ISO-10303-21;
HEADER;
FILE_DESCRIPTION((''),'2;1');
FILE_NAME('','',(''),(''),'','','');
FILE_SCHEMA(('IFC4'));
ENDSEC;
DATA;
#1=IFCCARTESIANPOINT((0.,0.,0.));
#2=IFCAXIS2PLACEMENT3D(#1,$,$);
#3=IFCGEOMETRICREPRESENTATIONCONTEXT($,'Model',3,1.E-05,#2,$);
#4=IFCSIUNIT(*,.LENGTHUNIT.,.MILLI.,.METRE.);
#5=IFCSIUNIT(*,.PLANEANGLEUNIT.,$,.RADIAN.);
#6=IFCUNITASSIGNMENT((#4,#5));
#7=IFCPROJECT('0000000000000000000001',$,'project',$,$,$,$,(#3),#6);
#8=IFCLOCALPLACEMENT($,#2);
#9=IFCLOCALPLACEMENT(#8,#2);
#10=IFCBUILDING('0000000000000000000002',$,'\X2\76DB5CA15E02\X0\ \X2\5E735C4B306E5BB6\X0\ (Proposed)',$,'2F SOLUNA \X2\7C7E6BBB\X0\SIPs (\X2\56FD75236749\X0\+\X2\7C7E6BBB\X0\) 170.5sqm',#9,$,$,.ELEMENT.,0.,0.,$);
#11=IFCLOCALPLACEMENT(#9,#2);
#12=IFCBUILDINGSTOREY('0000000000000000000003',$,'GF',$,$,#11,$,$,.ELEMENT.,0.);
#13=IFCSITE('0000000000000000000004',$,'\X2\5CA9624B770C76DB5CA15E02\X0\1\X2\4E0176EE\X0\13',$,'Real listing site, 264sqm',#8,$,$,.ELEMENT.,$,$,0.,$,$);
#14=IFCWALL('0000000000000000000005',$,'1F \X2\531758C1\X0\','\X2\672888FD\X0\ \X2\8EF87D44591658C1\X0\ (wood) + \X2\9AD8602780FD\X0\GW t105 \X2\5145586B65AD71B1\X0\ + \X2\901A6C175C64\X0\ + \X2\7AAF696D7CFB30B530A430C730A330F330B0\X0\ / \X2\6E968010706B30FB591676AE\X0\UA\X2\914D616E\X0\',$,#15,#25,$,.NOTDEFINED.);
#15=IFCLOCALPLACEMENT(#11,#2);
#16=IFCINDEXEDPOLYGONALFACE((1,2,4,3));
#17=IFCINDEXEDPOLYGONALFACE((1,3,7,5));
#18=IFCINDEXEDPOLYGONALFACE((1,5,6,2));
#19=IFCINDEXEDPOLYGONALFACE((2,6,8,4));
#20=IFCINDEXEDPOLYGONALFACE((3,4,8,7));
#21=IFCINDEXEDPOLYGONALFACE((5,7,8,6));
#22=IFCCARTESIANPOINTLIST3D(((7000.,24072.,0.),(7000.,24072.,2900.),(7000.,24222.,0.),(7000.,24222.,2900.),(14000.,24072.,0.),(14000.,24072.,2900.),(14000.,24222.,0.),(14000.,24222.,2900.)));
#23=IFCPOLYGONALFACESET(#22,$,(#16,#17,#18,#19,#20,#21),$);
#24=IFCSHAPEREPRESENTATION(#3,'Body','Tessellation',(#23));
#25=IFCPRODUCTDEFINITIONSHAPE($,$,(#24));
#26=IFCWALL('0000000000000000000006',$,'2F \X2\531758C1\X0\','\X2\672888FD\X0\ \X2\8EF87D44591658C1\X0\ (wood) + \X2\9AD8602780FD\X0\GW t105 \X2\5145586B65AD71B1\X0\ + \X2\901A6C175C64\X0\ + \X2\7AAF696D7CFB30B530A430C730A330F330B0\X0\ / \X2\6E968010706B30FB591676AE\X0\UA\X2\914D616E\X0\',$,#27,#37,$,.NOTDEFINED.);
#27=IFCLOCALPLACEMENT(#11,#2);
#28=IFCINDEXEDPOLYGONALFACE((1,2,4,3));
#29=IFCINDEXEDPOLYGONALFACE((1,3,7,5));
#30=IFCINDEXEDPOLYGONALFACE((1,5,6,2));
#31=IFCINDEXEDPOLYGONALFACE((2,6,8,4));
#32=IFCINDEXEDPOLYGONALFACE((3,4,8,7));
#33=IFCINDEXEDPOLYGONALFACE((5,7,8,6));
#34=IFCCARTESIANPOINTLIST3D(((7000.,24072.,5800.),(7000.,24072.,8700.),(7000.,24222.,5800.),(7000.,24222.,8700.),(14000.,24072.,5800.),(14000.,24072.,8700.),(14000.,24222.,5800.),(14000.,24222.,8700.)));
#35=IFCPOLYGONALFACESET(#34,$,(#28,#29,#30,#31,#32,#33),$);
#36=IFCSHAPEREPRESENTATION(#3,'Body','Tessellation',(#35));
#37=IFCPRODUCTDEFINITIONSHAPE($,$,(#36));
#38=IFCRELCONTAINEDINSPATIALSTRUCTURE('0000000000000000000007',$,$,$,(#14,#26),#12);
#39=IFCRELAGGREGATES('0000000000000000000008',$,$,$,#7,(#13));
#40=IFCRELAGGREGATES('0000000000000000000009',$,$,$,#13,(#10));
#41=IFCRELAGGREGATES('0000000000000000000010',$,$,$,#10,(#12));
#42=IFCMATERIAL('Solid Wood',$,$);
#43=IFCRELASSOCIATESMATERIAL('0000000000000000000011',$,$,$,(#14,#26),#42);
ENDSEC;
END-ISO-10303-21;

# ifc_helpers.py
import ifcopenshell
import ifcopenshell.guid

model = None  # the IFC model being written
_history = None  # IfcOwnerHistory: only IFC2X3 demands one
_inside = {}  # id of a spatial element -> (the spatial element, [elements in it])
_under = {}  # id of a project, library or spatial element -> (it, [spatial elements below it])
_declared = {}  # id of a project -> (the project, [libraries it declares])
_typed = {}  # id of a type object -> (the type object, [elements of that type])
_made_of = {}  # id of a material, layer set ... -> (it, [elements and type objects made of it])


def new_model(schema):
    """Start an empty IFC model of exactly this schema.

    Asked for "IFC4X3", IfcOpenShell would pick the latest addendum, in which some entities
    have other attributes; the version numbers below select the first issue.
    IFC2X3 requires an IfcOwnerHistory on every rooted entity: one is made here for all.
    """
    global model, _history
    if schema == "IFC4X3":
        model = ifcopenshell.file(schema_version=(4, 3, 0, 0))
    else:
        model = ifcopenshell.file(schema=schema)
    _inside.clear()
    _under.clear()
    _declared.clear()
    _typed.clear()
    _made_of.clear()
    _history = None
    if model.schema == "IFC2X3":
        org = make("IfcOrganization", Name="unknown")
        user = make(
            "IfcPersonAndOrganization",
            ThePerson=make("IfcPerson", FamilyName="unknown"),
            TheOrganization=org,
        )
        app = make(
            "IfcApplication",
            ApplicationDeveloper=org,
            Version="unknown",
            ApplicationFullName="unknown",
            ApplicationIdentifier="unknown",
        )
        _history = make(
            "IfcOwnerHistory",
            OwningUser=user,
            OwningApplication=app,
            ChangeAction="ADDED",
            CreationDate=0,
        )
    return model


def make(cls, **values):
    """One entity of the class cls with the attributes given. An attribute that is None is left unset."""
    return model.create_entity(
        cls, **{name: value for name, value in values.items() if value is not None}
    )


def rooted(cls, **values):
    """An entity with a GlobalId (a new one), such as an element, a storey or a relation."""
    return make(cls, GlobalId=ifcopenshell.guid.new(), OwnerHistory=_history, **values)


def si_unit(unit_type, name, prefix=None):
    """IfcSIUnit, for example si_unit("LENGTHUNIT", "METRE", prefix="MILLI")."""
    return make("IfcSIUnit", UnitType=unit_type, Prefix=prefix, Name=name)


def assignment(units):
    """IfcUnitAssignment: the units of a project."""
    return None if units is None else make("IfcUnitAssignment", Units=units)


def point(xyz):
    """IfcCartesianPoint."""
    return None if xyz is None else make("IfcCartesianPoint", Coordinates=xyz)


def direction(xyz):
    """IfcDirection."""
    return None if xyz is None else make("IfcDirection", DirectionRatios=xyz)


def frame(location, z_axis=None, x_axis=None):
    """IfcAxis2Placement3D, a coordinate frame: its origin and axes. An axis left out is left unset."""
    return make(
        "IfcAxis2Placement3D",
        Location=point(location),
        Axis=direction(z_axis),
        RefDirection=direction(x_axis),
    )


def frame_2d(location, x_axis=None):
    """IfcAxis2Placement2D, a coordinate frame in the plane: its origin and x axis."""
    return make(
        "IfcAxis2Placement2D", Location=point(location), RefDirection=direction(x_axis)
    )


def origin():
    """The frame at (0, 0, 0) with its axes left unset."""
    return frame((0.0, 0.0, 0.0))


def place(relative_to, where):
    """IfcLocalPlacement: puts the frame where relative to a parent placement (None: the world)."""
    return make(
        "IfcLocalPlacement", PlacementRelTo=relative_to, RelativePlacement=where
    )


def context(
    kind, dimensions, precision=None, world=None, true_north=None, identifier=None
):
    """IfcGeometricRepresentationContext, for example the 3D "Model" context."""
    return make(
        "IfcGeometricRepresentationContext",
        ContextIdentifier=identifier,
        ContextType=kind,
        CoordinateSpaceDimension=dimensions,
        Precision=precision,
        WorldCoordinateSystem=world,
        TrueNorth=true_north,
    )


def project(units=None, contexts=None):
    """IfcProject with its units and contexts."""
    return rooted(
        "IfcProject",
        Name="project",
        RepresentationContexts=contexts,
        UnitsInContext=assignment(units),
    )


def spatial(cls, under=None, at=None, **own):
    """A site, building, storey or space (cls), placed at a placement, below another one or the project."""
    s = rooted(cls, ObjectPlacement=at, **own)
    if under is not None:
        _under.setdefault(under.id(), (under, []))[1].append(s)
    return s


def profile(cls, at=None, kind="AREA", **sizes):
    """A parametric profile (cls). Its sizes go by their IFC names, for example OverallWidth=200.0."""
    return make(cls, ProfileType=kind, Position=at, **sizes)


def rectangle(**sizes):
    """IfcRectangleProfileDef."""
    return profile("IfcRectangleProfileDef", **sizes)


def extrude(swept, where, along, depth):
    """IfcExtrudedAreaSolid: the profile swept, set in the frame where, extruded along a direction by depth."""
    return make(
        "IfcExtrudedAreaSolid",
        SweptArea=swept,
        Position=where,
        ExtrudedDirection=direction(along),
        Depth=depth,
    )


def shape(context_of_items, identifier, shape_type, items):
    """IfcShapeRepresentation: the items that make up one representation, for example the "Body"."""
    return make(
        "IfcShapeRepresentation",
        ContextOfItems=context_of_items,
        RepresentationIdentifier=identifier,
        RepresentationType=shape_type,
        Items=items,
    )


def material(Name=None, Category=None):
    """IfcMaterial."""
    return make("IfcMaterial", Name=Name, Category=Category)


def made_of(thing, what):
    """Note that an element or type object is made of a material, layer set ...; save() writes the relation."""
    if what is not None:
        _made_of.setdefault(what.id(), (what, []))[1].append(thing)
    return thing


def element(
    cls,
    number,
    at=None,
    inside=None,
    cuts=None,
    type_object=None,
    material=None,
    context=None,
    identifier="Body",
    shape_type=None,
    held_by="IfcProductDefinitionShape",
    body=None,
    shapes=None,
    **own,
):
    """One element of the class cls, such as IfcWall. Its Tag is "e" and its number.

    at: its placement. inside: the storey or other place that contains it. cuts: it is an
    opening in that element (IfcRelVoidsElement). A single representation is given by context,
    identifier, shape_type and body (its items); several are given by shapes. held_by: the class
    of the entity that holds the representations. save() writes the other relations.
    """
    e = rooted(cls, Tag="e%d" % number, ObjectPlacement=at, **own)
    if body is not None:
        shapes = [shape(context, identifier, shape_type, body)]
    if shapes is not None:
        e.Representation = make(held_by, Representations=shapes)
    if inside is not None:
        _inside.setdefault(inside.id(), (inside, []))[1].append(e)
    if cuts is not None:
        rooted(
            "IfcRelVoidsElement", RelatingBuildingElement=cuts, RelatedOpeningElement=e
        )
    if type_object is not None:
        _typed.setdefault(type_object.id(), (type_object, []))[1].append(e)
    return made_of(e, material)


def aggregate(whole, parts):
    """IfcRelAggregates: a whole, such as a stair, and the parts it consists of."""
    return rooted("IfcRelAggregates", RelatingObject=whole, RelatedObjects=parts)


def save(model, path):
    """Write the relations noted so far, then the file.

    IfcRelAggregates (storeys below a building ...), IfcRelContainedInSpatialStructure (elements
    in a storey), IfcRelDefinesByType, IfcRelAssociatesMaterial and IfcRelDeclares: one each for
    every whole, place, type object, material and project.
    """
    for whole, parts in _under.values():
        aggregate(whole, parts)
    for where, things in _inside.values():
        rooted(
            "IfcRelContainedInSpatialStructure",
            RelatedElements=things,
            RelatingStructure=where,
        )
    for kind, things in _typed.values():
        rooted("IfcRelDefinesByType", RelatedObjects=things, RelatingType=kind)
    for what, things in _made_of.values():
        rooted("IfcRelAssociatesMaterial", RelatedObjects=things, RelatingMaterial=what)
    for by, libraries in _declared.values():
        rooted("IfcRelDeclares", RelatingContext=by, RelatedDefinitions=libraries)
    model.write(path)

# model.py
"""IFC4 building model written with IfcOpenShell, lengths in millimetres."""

from ifc_helpers import new_model, si_unit, frame, frame_2d, origin, place, context, project, spatial, rectangle, extrude, material, element, save


model = new_model("IFC4")

# Units and contexts
model_context = context("Model", 3, precision=1e-05, world=origin())
ifc_project = project(units=[si_unit("LENGTHUNIT", "METRE", prefix="MILLI"), si_unit("PLANEANGLEUNIT", "RADIAN")], contexts=[model_context])

# Site, building, storey
site_placement = place(None, origin())
site = spatial("IfcSite", under=ifc_project, at=site_placement, Name="岩手県盛岡市1丁目13", ObjectType="Real listing site, 264sqm", CompositionType="ELEMENT", RefElevation=0.0)
building_placement = place(site_placement, origin())
building = spatial("IfcBuilding", under=site, at=building_placement, Name="盛岡市 平屋の家 (Proposed)", ObjectType="2F SOLUNA 籾殻SIPs (国産杉+籾殻) 170.5sqm", CompositionType="ELEMENT", ElevationOfRefHeight=0.0, ElevationOfTerrain=0.0)
storey_placement = place(building_placement, origin())
storey = spatial("IfcBuildingStorey", under=building, at=storey_placement, Name="GF", CompositionType="ELEMENT", Elevation=0.0)

# Shared definitions
ifc_material_1 = material(Name="Solid Wood")

# Wall
wall_1_placement = place(storey_placement, frame((3500.0, 12036.0, 0.0)))
element("IfcWall", 1, at=wall_1_placement, inside=storey, material=ifc_material_1, Name="1F 北壁", Description="木製 軸組外壁 (wood) + 高性能GW t105 充填断熱 + 通気層 + 窯業系サイディング / 準耐火・外皮UA配慮", PredefinedType="NOTDEFINED", context=model_context, shape_type="SweptSolid", body=[
    extrude(rectangle(XDim=7000.0, YDim=150.0, at=frame_2d((3500.0, 75.0))), frame((3500.0, 12036.0, 0.0)), (0.0, 0.0, 1.0), 2900.0),
])

# Wall
wall_2_placement = place(storey_placement, frame((3500.0, 12036.0, 2900.0)))
element("IfcWall", 2, at=wall_2_placement, inside=storey, material=ifc_material_1, Name="2F 北壁", Description="木製 軸組外壁 (wood) + 高性能GW t105 充填断熱 + 通気層 + 窯業系サイディング / 準耐火・外皮UA配慮", PredefinedType="NOTDEFINED", context=model_context, shape_type="SweptSolid", body=[
    extrude(rectangle(XDim=7000.0, YDim=150.0, at=frame_2d((3500.0, 75.0))), frame((3500.0, 12036.0, 2900.0)), (0.0, 0.0, 1.0), 2900.0),
])

save(model, "model.ifc")
